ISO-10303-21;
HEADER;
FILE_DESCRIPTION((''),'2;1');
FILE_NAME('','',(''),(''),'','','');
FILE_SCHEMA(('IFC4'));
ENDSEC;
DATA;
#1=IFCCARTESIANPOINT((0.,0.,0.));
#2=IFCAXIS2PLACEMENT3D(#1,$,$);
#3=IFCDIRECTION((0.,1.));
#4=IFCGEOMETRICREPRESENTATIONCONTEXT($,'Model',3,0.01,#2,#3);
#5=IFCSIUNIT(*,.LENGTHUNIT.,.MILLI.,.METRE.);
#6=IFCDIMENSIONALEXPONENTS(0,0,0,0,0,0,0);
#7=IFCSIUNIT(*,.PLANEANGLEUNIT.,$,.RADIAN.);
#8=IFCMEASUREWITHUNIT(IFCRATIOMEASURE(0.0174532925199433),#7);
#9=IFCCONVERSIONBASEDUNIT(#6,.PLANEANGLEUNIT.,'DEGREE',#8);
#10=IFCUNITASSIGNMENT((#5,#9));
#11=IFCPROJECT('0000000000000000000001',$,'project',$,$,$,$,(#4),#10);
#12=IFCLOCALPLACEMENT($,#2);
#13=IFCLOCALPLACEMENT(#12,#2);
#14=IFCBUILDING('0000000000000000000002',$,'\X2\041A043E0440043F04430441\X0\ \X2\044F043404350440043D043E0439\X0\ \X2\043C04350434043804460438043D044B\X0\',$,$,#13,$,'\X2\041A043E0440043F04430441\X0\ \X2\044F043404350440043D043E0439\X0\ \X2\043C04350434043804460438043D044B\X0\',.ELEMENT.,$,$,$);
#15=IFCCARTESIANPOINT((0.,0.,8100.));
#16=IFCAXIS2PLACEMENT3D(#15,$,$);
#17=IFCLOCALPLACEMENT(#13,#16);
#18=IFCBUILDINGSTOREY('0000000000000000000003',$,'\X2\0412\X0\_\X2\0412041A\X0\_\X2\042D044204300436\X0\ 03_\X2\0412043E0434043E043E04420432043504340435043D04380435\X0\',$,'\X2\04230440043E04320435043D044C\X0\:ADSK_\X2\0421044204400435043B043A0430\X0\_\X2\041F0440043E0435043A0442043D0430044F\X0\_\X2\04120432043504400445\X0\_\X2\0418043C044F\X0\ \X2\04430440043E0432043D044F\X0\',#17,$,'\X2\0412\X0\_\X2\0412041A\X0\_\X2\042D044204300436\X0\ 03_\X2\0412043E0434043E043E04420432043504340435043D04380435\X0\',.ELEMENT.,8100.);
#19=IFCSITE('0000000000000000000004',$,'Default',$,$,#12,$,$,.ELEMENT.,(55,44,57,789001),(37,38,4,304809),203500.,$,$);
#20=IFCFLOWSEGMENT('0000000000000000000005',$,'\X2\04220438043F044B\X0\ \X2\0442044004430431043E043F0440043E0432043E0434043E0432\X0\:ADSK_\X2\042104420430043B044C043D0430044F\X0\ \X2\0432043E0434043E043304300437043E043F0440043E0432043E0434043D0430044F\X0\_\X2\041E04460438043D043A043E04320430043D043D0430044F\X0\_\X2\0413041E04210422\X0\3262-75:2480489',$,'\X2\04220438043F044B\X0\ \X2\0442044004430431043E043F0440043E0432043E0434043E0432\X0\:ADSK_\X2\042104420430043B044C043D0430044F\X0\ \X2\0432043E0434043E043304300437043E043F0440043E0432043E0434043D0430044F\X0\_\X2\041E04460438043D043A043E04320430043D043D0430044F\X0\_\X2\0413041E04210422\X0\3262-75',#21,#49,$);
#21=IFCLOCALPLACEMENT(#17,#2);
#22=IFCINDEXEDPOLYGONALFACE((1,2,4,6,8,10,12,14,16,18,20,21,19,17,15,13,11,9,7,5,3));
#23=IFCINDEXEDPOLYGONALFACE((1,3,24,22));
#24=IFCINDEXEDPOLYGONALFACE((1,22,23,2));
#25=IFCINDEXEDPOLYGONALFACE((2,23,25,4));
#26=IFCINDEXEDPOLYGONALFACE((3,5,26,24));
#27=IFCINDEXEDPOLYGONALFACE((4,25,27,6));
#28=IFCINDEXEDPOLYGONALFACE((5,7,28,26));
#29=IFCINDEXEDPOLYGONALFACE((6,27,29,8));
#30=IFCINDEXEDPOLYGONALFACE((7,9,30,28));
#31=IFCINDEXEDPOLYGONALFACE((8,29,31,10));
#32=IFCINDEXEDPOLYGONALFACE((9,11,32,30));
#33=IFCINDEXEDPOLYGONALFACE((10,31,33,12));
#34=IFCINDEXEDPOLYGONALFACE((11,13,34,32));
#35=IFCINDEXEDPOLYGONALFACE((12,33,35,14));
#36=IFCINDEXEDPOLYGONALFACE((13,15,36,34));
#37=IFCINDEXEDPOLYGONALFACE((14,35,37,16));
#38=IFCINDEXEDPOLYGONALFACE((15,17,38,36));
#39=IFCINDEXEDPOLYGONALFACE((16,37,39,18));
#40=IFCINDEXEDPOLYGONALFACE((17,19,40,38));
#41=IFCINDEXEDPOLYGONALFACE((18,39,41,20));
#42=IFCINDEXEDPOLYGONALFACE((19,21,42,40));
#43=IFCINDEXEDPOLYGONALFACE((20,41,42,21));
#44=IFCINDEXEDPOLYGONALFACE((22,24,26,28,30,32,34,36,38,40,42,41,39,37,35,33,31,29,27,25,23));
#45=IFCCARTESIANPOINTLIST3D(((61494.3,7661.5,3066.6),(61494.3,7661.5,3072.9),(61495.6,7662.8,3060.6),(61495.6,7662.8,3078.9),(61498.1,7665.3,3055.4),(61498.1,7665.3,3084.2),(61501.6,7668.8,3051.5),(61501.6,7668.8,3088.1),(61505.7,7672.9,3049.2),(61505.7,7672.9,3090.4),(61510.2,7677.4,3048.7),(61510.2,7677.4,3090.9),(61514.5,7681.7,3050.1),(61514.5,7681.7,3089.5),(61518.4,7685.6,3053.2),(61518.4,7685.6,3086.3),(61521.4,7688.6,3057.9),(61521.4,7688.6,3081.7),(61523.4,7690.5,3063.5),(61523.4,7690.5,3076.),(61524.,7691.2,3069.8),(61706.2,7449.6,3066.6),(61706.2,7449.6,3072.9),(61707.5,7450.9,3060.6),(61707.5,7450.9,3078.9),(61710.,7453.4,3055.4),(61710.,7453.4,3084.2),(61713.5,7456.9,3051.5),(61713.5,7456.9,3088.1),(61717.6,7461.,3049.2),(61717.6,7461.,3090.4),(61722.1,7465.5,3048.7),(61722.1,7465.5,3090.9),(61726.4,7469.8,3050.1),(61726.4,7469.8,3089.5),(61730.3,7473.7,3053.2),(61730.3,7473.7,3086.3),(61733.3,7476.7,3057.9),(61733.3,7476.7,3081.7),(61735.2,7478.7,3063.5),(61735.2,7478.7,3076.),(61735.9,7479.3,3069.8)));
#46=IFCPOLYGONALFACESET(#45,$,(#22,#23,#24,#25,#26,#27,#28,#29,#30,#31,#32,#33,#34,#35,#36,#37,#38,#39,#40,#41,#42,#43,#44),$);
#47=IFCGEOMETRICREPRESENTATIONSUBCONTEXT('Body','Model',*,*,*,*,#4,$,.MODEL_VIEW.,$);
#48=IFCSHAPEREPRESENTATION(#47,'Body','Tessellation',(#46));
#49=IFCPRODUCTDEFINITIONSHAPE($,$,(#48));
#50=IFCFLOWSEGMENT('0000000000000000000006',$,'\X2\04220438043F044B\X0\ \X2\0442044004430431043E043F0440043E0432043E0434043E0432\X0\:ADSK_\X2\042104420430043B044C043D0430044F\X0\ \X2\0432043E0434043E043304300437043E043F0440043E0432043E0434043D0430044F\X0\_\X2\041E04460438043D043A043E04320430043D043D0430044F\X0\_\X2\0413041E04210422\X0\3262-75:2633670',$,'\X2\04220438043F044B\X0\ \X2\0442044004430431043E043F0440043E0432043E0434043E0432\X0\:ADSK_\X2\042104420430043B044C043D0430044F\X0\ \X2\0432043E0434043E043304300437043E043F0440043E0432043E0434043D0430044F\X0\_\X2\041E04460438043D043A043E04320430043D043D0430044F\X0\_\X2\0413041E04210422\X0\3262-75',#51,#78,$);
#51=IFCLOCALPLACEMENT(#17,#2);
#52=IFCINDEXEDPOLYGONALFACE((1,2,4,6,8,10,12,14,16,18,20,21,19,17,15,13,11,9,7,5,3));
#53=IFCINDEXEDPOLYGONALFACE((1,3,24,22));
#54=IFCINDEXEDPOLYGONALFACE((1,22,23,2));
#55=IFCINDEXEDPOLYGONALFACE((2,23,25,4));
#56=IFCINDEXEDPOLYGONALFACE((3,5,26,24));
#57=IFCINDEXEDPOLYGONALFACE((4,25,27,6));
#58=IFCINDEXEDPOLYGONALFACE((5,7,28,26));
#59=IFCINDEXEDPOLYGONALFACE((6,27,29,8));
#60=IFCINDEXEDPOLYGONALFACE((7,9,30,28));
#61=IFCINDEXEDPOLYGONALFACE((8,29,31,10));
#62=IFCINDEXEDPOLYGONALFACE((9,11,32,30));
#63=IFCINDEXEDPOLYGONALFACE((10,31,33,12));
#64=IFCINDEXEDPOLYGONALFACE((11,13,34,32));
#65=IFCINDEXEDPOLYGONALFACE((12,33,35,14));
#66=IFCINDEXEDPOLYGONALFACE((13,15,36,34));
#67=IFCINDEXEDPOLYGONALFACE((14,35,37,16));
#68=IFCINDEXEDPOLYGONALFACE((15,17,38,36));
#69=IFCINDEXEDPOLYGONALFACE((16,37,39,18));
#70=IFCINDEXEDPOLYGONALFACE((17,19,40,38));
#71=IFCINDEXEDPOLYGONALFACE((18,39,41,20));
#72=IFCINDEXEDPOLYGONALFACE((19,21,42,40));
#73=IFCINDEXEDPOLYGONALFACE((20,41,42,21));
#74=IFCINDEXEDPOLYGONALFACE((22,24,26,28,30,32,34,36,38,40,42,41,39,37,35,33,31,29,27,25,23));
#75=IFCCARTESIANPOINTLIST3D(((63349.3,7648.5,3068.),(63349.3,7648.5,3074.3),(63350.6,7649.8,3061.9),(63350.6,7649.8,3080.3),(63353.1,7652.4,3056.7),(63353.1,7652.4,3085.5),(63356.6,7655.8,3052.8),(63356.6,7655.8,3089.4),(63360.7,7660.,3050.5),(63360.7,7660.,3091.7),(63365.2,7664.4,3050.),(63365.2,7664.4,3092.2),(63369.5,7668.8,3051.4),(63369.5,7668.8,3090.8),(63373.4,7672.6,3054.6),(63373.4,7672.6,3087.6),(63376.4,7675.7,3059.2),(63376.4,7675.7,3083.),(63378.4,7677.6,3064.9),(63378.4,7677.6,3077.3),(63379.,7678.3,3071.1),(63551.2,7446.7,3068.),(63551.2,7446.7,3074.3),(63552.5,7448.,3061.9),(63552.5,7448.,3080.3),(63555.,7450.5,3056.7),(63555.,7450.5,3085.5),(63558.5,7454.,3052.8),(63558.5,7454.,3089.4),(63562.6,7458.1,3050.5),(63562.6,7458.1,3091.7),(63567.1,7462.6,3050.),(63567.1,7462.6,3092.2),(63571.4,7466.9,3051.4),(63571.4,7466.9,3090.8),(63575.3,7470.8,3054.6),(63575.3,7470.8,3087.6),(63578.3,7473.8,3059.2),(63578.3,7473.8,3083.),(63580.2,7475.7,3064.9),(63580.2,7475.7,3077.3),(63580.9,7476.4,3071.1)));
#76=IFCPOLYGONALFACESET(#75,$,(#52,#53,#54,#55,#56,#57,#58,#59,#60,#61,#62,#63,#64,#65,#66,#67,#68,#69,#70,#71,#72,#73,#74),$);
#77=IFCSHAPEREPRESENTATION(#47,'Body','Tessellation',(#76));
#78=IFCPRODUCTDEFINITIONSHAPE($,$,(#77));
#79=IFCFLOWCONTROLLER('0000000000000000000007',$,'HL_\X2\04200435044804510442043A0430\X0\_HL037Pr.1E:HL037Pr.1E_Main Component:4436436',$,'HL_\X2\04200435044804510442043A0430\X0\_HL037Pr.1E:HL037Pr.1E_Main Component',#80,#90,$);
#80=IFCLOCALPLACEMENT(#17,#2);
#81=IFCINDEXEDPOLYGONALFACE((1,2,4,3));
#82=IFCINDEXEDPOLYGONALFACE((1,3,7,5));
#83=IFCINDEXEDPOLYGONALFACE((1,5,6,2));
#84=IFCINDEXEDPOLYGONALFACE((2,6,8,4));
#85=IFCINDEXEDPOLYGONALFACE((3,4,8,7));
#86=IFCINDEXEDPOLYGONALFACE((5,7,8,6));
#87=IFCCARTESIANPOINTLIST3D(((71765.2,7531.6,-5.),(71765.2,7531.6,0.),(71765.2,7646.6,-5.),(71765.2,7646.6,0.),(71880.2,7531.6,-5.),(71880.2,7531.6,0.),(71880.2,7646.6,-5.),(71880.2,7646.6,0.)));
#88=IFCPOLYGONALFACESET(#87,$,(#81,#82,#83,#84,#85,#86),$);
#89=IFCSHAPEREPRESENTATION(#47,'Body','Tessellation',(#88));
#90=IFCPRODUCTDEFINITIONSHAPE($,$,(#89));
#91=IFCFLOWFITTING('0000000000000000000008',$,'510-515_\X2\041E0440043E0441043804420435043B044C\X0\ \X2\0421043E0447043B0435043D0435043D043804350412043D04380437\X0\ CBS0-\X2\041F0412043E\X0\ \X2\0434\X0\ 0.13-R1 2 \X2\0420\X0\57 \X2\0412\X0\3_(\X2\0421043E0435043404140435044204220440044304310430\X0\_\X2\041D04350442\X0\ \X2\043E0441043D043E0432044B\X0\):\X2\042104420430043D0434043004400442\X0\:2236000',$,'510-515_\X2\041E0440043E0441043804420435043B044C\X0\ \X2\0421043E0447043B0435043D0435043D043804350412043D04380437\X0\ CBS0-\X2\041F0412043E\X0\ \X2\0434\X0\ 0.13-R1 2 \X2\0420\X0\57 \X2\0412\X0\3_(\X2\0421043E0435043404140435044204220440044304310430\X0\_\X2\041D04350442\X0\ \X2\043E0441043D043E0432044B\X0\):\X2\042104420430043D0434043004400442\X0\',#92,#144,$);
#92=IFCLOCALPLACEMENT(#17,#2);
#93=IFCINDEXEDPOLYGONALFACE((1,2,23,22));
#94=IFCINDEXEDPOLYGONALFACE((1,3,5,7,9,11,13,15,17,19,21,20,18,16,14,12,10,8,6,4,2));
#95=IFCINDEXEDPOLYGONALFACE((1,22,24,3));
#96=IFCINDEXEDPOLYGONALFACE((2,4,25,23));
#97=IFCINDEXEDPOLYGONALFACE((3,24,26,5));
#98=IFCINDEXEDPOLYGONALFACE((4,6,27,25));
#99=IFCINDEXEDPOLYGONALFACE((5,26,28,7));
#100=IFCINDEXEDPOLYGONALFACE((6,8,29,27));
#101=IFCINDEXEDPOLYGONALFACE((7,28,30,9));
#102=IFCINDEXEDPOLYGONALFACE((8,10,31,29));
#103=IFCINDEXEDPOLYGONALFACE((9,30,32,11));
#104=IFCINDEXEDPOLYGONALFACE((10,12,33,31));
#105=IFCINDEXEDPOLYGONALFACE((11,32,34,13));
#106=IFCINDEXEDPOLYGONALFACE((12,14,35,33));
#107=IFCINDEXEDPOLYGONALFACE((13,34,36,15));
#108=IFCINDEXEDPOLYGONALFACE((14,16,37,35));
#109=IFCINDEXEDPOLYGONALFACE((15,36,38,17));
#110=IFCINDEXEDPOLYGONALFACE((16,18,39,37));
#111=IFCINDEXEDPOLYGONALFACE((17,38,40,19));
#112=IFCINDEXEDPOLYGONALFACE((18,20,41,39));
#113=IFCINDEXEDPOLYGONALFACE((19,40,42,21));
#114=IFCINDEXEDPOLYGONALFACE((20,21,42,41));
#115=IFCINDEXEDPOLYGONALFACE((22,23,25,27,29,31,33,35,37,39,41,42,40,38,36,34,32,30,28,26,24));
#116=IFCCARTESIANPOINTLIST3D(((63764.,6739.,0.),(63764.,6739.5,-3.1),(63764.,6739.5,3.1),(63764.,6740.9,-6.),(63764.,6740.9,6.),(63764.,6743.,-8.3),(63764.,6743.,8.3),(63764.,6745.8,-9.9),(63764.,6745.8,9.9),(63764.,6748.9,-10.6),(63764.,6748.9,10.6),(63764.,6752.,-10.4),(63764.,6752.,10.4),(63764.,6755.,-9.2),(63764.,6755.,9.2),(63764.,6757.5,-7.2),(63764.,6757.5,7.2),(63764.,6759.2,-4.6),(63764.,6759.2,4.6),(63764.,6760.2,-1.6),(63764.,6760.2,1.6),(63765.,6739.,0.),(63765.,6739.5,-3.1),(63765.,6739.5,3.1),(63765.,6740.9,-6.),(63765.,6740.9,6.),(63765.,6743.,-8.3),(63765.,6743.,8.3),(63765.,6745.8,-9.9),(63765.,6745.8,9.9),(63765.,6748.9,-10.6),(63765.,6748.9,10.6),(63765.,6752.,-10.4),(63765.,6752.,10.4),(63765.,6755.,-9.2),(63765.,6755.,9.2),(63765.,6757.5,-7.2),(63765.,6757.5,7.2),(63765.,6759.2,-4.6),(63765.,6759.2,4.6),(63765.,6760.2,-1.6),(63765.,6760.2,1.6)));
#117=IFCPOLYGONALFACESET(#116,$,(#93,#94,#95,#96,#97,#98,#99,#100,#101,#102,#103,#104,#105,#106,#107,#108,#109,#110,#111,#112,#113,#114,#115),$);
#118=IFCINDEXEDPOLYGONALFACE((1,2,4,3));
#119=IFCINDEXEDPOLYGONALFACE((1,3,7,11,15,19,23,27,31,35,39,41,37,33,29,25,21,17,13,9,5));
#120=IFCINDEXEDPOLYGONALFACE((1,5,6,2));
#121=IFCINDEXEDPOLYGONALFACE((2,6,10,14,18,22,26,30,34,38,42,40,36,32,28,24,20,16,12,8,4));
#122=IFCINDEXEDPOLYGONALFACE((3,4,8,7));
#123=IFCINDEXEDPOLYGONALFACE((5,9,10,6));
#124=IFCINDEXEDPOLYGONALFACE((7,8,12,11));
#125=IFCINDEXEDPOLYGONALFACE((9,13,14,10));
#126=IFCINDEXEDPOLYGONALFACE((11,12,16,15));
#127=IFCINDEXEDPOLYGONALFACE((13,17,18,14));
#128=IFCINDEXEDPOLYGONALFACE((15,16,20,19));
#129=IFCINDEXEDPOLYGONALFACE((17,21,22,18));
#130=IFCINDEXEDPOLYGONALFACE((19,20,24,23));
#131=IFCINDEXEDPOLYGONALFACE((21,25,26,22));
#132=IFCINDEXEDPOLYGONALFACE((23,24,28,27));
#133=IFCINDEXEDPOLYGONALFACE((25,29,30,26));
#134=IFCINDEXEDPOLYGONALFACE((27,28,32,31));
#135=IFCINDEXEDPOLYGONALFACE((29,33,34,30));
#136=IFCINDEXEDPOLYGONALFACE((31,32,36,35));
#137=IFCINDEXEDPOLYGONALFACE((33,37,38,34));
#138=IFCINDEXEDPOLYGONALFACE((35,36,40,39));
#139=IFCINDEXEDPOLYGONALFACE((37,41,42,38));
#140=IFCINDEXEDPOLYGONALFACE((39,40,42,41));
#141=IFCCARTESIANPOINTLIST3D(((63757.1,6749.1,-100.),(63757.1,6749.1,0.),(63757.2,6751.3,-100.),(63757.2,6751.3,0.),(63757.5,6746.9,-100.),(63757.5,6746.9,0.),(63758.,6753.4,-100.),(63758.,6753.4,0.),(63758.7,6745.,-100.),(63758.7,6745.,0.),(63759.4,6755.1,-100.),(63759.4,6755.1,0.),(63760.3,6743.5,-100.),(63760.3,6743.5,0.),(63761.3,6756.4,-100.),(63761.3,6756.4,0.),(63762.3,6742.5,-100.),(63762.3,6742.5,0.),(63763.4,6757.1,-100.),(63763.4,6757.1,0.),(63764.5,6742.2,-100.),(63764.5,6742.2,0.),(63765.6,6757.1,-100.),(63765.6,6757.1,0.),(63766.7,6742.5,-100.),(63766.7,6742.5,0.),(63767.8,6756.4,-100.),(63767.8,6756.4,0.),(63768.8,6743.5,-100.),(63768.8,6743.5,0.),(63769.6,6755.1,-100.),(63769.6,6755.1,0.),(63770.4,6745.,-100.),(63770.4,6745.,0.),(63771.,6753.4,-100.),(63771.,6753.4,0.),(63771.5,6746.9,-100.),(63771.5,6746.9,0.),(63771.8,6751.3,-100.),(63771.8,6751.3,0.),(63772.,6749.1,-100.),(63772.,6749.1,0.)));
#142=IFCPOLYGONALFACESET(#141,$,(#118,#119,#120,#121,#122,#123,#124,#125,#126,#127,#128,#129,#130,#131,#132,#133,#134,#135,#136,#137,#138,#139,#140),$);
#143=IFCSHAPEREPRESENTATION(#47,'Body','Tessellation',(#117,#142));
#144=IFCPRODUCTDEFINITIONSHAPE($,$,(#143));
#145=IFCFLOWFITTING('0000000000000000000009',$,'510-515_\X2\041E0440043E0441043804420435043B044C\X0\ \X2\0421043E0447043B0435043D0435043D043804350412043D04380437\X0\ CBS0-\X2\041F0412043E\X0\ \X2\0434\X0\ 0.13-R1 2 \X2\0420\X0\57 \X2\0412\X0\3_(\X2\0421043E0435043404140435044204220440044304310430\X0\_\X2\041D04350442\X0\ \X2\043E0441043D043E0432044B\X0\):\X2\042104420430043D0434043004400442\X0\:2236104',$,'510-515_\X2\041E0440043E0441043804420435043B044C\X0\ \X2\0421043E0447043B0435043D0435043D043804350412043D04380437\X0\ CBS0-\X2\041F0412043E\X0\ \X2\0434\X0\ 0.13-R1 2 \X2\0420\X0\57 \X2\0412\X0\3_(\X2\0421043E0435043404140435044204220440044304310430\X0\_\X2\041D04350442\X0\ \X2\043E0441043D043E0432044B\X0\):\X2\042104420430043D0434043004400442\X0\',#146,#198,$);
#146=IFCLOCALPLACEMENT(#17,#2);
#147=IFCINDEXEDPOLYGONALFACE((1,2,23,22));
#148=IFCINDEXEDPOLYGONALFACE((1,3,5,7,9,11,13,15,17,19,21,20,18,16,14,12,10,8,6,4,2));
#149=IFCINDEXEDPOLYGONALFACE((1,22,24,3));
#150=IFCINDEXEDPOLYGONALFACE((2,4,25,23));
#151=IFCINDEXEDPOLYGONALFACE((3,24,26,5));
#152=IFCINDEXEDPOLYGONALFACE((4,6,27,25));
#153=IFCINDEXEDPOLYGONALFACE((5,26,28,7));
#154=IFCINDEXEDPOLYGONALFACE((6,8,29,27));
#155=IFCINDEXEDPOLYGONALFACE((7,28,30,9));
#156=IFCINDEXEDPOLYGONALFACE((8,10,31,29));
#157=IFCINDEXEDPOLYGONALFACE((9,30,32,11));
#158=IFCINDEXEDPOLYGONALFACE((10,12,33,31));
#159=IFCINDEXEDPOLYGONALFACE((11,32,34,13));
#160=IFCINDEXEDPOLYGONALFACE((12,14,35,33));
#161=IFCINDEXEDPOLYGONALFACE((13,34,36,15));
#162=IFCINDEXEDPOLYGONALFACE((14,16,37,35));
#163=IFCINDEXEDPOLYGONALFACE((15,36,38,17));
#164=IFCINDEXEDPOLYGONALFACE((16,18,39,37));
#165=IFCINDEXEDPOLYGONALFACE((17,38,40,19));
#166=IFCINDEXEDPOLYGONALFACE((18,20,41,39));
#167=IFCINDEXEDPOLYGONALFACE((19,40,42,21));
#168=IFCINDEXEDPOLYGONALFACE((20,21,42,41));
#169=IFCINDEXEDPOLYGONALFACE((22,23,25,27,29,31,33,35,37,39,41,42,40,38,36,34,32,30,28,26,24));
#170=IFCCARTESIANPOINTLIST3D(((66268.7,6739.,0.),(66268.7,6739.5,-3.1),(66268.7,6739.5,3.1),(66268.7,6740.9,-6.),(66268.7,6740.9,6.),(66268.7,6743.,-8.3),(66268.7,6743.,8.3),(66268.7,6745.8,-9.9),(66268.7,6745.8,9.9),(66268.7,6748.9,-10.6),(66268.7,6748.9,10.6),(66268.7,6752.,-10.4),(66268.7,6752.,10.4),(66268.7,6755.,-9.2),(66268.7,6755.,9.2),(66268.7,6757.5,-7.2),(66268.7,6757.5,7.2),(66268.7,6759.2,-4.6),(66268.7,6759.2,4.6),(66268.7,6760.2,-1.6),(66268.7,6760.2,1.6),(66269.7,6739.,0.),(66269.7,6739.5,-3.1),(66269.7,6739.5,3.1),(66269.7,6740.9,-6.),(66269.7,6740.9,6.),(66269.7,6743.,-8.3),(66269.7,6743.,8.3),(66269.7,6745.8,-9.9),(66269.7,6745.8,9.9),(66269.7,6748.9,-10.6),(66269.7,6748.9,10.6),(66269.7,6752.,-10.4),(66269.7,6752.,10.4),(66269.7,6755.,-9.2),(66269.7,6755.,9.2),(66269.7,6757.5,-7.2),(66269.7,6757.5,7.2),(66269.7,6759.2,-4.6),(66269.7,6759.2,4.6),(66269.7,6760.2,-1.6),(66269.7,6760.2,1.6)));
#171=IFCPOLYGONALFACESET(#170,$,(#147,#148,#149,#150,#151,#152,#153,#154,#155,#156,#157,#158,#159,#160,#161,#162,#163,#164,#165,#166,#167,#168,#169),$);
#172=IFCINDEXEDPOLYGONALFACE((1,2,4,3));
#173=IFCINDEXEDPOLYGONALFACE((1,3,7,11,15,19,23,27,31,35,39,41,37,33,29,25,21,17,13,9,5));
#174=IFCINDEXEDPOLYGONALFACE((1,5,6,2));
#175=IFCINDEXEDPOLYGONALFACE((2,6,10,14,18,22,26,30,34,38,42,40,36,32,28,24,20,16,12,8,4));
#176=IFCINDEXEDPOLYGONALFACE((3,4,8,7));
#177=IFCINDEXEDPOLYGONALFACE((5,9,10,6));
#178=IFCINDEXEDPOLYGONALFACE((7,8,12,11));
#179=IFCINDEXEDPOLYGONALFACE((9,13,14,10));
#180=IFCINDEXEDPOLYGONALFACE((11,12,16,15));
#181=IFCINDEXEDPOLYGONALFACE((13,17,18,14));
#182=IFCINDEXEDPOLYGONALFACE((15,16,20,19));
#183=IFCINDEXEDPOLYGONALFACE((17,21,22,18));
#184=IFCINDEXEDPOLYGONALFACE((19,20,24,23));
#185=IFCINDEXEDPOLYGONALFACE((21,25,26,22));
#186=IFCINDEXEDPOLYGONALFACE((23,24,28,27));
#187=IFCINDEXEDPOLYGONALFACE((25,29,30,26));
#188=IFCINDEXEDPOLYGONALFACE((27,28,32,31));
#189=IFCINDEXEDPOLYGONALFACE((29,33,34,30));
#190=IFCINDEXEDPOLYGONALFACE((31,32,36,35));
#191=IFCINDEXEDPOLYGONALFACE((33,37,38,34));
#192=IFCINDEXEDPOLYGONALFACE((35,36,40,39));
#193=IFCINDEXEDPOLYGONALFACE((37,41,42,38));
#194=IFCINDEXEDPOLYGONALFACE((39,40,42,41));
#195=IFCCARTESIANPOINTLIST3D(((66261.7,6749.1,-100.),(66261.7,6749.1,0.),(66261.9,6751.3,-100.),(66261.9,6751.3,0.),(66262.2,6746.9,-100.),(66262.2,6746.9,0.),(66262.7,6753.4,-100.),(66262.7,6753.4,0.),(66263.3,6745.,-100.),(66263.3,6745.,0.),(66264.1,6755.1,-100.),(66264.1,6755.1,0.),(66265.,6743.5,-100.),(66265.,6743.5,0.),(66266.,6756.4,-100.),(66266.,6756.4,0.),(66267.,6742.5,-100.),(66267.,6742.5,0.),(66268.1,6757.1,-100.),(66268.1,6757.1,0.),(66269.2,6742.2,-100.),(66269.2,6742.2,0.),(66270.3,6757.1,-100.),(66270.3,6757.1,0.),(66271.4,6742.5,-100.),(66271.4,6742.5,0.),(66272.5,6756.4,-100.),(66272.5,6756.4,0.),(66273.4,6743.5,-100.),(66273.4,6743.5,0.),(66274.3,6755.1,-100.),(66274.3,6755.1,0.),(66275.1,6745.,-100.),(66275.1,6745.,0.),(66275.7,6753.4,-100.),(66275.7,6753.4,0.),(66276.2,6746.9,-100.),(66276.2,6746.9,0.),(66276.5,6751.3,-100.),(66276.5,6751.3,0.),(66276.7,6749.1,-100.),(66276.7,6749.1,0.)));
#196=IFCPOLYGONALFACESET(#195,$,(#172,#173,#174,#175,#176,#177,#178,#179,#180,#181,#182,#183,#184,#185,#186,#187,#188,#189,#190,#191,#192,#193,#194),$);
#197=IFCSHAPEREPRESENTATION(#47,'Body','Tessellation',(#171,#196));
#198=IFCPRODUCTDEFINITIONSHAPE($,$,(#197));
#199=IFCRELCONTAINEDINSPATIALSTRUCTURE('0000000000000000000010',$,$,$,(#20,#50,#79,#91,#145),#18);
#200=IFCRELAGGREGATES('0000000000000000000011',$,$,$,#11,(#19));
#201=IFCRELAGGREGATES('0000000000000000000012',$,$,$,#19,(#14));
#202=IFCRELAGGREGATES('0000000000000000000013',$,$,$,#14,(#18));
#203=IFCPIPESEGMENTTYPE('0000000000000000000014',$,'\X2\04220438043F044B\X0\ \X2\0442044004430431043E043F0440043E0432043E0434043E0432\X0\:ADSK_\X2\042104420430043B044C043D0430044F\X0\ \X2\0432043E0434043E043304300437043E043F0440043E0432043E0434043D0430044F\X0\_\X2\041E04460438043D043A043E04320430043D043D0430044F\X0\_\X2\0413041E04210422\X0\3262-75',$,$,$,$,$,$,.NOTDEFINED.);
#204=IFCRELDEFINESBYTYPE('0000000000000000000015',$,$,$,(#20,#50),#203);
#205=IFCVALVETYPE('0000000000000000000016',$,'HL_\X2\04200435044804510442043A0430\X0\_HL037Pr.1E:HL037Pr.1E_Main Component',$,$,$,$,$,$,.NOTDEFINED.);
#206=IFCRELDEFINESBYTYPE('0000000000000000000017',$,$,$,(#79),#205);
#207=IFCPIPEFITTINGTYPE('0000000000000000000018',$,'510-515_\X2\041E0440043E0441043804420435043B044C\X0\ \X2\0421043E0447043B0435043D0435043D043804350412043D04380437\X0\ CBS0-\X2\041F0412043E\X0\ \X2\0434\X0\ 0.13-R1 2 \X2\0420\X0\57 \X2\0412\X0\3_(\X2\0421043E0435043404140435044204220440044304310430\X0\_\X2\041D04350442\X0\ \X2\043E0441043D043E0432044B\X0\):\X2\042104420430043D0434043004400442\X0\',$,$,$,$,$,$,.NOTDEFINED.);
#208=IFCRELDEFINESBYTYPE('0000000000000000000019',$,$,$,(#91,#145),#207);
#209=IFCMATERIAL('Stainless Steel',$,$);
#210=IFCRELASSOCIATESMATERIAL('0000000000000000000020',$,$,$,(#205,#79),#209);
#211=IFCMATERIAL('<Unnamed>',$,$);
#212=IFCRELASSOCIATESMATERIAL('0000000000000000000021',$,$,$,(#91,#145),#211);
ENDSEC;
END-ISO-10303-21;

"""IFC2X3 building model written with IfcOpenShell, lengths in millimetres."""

from ifc_helpers import new_model, entity, si_unit, converted_unit, direction, frame, origin, origin_2d_with_axis, place, context, subcontext, project, spatial, rectangle, circle, extrude, source, transform, mapped, material, type_object, type_shapes, element, save


model = new_model("IFC2X3")

# Units and contexts
model_context = context("Model", 3, precision=0.01, world=origin(), true_north=direction((0.0, 1.0)))
body_context = subcontext(model_context, "Body", "Model", "MODEL_VIEW")
ifc_project = project(units=[si_unit("LENGTHUNIT", "METRE", prefix="MILLI"), converted_unit("PLANEANGLEUNIT", "DEGREE", entity("IfcRatioMeasure", 0.0174532925199433), si_unit("PLANEANGLEUNIT", "RADIAN"), dimensions=[0, 0, 0, 0, 0, 0, 0])], contexts=[model_context])

# Site, building, storey
site_placement = place(None, origin())
site = spatial("IfcSite", under=ifc_project, at=site_placement, Name="Default", CompositionType="ELEMENT", RefLatitude=(55, 44, 57, 789001), RefLongitude=(37, 38, 4, 304809), RefElevation=203500.0)
building_placement = place(site_placement, origin())
building = spatial("IfcBuilding", under=site, at=building_placement, Name="Корпус ядерной медицины", LongName="Корпус ядерной медицины", CompositionType="ELEMENT")
storey_placement = place(building_placement, frame((0.0, 0.0, 8100.0)))
storey = spatial("IfcBuildingStorey", under=building, at=storey_placement, Name="В_ВК_Этаж 03_Водоотведение", ObjectType="Уровень:ADSK_Стрелка_Проектная_Вверх_Имя уровня", LongName="В_ВК_Этаж 03_Водоотведение", CompositionType="ELEMENT", Elevation=8100.0)

# Flow segments
pipe_segment_type_1 = type_object("IfcPipeSegmentType", Name="Типы трубопроводов:ADSK_Стальная водогазопроводная_Оцинкованная_ГОСТ3262-75", PredefinedType="NOTDEFINED")
flow_segment_1_placement = place(storey_placement, frame((61492.5, 7447.8, 3047.0)))
element("IfcFlowSegment", 1, at=flow_segment_1_placement, inside=storey, type_object=pipe_segment_type_1, Name="Типы трубопроводов:ADSK_Стальная водогазопроводная_Оцинкованная_ГОСТ3262-75:2480489", ObjectType="Типы трубопроводов:ADSK_Стальная водогазопроводная_Оцинкованная_ГОСТ3262-75", context=body_context, shape_type="SweptSolid", body=[
    extrude(circle(Radius=21.1, at=origin_2d_with_axis()), frame((16.6, 228.4, 22.8), z_axis=(0.707107, -0.707107, 0.0), x_axis=(0.707107, 0.707107, 0.0)), (0.0, 0.0, 1.0), 299.6),
])
flow_segment_2_placement = place(storey_placement, frame((63347.5, 7444.9, 3048.4)))
element("IfcFlowSegment", 2, at=flow_segment_2_placement, inside=storey, type_object=pipe_segment_type_1, Name="Типы трубопроводов:ADSK_Стальная водогазопроводная_Оцинкованная_ГОСТ3262-75:2633670", ObjectType="Типы трубопроводов:ADSK_Стальная водогазопроводная_Оцинкованная_ГОСТ3262-75", context=body_context, shape_type="SweptSolid", body=[
    extrude(circle(Radius=21.1, at=origin_2d_with_axis()), frame((16.6, 218.4, 22.8), z_axis=(0.707107, -0.707107, 0.0), x_axis=(0.707107, 0.707107, 0.0)), (0.0, 0.0, 1.0), 285.5),
])

# Flow controller
ifc_material_1 = material(Name="Stainless Steel")
valve_type = type_object("IfcValveType", Name="HL_Решётка_HL037Pr.1E:HL037Pr.1E_Main Component", PredefinedType="NOTDEFINED", material=ifc_material_1)
shared_shape_1 = source(origin(), body_context, "Body", "SweptSolid", [
    extrude(rectangle(XDim=115.0, YDim=115.0, at=origin_2d_with_axis()), frame((0.0, 0.0, -5.0), z_axis=(0.0, 0.0, 1.0), x_axis=(0.0, -1.0, 0.0)), (0.0, 0.0, 1.0), 5.0),
])
type_shapes(valve_type, [shared_shape_1])
flow_controller_placement = place(storey_placement, frame((71822.7, 7589.1, 0.0), z_axis=(0.0, 0.0, 1.0), x_axis=(-1.0, 0.0, 0.0)))
element("IfcFlowController", 3, at=flow_controller_placement, inside=storey, type_object=valve_type, material=ifc_material_1, Name="HL_Решётка_HL037Pr.1E:HL037Pr.1E_Main Component:4436436", ObjectType="HL_Решётка_HL037Pr.1E:HL037Pr.1E_Main Component", context=body_context, shape_type="MappedRepresentation", body=[
    mapped(shared_shape_1, transform((0.0, 0.0, 0.0), scale=1.0)),
])

# Flow fittings
ifc_material_2 = material(Name="<Unnamed>")
pipe_fitting_type = type_object("IfcPipeFittingType", Name="510-515_Ороситель СочленениеВниз CBS0-ПВо д 0.13-R1 2 Р57 В3_(СоедДетТруба_Нет основы):Стандарт", PredefinedType="NOTDEFINED")
shared_shape_2 = source(origin(), body_context, "Body", "SweptSolid", [
    extrude(circle(Radius=10.7, at=origin_2d_with_axis()), frame((-0.5, 0.0, 0.0), z_axis=(1.0, 0.0, 0.0), x_axis=(0.0, 1.0, 0.0)), (0.0, 0.0, 1.0), 1.0),
    extrude(circle(Radius=7.5, at=origin_2d_with_axis()), frame((0.0, 0.0, -100.0), z_axis=(0.0, 0.0, 1.0), x_axis=(0.0, 1.0, 0.0)), (0.0, 0.0, 1.0), 100.0),
])
type_shapes(pipe_fitting_type, [shared_shape_2])
for number, where, z_axis, x_axis, name in (
    (4, (63764.5, 6749.6, 0.0), (0.0, 0.0, 1.0), (-1.0, 0.0, 0.0), "510-515_Ороситель СочленениеВниз CBS0-ПВо д 0.13-R1 2 Р57 В3_(СоедДетТруба_Нет основы):Стандарт:2236000"),
    (5, (66269.2, 6749.6, 0.0), (0.0, 0.0, 1.0), (-1.0, 0.0, 0.0), "510-515_Ороситель СочленениеВниз CBS0-ПВо д 0.13-R1 2 Р57 В3_(СоедДетТруба_Нет основы):Стандарт:2236104"),
):
    element("IfcFlowFitting", number, at=place(storey_placement, frame(where, z_axis=z_axis, x_axis=x_axis)), inside=storey, type_object=pipe_fitting_type, material=ifc_material_2, Name=name, ObjectType="510-515_Ороситель СочленениеВниз CBS0-ПВо д 0.13-R1 2 Р57 В3_(СоедДетТруба_Нет основы):Стандарт", context=body_context, shape_type="MappedRepresentation", body=[
        mapped(shared_shape_2, transform((0.0, 0.0, 0.0), scale=1.0)),
    ])

save(model, "model.ifc")
